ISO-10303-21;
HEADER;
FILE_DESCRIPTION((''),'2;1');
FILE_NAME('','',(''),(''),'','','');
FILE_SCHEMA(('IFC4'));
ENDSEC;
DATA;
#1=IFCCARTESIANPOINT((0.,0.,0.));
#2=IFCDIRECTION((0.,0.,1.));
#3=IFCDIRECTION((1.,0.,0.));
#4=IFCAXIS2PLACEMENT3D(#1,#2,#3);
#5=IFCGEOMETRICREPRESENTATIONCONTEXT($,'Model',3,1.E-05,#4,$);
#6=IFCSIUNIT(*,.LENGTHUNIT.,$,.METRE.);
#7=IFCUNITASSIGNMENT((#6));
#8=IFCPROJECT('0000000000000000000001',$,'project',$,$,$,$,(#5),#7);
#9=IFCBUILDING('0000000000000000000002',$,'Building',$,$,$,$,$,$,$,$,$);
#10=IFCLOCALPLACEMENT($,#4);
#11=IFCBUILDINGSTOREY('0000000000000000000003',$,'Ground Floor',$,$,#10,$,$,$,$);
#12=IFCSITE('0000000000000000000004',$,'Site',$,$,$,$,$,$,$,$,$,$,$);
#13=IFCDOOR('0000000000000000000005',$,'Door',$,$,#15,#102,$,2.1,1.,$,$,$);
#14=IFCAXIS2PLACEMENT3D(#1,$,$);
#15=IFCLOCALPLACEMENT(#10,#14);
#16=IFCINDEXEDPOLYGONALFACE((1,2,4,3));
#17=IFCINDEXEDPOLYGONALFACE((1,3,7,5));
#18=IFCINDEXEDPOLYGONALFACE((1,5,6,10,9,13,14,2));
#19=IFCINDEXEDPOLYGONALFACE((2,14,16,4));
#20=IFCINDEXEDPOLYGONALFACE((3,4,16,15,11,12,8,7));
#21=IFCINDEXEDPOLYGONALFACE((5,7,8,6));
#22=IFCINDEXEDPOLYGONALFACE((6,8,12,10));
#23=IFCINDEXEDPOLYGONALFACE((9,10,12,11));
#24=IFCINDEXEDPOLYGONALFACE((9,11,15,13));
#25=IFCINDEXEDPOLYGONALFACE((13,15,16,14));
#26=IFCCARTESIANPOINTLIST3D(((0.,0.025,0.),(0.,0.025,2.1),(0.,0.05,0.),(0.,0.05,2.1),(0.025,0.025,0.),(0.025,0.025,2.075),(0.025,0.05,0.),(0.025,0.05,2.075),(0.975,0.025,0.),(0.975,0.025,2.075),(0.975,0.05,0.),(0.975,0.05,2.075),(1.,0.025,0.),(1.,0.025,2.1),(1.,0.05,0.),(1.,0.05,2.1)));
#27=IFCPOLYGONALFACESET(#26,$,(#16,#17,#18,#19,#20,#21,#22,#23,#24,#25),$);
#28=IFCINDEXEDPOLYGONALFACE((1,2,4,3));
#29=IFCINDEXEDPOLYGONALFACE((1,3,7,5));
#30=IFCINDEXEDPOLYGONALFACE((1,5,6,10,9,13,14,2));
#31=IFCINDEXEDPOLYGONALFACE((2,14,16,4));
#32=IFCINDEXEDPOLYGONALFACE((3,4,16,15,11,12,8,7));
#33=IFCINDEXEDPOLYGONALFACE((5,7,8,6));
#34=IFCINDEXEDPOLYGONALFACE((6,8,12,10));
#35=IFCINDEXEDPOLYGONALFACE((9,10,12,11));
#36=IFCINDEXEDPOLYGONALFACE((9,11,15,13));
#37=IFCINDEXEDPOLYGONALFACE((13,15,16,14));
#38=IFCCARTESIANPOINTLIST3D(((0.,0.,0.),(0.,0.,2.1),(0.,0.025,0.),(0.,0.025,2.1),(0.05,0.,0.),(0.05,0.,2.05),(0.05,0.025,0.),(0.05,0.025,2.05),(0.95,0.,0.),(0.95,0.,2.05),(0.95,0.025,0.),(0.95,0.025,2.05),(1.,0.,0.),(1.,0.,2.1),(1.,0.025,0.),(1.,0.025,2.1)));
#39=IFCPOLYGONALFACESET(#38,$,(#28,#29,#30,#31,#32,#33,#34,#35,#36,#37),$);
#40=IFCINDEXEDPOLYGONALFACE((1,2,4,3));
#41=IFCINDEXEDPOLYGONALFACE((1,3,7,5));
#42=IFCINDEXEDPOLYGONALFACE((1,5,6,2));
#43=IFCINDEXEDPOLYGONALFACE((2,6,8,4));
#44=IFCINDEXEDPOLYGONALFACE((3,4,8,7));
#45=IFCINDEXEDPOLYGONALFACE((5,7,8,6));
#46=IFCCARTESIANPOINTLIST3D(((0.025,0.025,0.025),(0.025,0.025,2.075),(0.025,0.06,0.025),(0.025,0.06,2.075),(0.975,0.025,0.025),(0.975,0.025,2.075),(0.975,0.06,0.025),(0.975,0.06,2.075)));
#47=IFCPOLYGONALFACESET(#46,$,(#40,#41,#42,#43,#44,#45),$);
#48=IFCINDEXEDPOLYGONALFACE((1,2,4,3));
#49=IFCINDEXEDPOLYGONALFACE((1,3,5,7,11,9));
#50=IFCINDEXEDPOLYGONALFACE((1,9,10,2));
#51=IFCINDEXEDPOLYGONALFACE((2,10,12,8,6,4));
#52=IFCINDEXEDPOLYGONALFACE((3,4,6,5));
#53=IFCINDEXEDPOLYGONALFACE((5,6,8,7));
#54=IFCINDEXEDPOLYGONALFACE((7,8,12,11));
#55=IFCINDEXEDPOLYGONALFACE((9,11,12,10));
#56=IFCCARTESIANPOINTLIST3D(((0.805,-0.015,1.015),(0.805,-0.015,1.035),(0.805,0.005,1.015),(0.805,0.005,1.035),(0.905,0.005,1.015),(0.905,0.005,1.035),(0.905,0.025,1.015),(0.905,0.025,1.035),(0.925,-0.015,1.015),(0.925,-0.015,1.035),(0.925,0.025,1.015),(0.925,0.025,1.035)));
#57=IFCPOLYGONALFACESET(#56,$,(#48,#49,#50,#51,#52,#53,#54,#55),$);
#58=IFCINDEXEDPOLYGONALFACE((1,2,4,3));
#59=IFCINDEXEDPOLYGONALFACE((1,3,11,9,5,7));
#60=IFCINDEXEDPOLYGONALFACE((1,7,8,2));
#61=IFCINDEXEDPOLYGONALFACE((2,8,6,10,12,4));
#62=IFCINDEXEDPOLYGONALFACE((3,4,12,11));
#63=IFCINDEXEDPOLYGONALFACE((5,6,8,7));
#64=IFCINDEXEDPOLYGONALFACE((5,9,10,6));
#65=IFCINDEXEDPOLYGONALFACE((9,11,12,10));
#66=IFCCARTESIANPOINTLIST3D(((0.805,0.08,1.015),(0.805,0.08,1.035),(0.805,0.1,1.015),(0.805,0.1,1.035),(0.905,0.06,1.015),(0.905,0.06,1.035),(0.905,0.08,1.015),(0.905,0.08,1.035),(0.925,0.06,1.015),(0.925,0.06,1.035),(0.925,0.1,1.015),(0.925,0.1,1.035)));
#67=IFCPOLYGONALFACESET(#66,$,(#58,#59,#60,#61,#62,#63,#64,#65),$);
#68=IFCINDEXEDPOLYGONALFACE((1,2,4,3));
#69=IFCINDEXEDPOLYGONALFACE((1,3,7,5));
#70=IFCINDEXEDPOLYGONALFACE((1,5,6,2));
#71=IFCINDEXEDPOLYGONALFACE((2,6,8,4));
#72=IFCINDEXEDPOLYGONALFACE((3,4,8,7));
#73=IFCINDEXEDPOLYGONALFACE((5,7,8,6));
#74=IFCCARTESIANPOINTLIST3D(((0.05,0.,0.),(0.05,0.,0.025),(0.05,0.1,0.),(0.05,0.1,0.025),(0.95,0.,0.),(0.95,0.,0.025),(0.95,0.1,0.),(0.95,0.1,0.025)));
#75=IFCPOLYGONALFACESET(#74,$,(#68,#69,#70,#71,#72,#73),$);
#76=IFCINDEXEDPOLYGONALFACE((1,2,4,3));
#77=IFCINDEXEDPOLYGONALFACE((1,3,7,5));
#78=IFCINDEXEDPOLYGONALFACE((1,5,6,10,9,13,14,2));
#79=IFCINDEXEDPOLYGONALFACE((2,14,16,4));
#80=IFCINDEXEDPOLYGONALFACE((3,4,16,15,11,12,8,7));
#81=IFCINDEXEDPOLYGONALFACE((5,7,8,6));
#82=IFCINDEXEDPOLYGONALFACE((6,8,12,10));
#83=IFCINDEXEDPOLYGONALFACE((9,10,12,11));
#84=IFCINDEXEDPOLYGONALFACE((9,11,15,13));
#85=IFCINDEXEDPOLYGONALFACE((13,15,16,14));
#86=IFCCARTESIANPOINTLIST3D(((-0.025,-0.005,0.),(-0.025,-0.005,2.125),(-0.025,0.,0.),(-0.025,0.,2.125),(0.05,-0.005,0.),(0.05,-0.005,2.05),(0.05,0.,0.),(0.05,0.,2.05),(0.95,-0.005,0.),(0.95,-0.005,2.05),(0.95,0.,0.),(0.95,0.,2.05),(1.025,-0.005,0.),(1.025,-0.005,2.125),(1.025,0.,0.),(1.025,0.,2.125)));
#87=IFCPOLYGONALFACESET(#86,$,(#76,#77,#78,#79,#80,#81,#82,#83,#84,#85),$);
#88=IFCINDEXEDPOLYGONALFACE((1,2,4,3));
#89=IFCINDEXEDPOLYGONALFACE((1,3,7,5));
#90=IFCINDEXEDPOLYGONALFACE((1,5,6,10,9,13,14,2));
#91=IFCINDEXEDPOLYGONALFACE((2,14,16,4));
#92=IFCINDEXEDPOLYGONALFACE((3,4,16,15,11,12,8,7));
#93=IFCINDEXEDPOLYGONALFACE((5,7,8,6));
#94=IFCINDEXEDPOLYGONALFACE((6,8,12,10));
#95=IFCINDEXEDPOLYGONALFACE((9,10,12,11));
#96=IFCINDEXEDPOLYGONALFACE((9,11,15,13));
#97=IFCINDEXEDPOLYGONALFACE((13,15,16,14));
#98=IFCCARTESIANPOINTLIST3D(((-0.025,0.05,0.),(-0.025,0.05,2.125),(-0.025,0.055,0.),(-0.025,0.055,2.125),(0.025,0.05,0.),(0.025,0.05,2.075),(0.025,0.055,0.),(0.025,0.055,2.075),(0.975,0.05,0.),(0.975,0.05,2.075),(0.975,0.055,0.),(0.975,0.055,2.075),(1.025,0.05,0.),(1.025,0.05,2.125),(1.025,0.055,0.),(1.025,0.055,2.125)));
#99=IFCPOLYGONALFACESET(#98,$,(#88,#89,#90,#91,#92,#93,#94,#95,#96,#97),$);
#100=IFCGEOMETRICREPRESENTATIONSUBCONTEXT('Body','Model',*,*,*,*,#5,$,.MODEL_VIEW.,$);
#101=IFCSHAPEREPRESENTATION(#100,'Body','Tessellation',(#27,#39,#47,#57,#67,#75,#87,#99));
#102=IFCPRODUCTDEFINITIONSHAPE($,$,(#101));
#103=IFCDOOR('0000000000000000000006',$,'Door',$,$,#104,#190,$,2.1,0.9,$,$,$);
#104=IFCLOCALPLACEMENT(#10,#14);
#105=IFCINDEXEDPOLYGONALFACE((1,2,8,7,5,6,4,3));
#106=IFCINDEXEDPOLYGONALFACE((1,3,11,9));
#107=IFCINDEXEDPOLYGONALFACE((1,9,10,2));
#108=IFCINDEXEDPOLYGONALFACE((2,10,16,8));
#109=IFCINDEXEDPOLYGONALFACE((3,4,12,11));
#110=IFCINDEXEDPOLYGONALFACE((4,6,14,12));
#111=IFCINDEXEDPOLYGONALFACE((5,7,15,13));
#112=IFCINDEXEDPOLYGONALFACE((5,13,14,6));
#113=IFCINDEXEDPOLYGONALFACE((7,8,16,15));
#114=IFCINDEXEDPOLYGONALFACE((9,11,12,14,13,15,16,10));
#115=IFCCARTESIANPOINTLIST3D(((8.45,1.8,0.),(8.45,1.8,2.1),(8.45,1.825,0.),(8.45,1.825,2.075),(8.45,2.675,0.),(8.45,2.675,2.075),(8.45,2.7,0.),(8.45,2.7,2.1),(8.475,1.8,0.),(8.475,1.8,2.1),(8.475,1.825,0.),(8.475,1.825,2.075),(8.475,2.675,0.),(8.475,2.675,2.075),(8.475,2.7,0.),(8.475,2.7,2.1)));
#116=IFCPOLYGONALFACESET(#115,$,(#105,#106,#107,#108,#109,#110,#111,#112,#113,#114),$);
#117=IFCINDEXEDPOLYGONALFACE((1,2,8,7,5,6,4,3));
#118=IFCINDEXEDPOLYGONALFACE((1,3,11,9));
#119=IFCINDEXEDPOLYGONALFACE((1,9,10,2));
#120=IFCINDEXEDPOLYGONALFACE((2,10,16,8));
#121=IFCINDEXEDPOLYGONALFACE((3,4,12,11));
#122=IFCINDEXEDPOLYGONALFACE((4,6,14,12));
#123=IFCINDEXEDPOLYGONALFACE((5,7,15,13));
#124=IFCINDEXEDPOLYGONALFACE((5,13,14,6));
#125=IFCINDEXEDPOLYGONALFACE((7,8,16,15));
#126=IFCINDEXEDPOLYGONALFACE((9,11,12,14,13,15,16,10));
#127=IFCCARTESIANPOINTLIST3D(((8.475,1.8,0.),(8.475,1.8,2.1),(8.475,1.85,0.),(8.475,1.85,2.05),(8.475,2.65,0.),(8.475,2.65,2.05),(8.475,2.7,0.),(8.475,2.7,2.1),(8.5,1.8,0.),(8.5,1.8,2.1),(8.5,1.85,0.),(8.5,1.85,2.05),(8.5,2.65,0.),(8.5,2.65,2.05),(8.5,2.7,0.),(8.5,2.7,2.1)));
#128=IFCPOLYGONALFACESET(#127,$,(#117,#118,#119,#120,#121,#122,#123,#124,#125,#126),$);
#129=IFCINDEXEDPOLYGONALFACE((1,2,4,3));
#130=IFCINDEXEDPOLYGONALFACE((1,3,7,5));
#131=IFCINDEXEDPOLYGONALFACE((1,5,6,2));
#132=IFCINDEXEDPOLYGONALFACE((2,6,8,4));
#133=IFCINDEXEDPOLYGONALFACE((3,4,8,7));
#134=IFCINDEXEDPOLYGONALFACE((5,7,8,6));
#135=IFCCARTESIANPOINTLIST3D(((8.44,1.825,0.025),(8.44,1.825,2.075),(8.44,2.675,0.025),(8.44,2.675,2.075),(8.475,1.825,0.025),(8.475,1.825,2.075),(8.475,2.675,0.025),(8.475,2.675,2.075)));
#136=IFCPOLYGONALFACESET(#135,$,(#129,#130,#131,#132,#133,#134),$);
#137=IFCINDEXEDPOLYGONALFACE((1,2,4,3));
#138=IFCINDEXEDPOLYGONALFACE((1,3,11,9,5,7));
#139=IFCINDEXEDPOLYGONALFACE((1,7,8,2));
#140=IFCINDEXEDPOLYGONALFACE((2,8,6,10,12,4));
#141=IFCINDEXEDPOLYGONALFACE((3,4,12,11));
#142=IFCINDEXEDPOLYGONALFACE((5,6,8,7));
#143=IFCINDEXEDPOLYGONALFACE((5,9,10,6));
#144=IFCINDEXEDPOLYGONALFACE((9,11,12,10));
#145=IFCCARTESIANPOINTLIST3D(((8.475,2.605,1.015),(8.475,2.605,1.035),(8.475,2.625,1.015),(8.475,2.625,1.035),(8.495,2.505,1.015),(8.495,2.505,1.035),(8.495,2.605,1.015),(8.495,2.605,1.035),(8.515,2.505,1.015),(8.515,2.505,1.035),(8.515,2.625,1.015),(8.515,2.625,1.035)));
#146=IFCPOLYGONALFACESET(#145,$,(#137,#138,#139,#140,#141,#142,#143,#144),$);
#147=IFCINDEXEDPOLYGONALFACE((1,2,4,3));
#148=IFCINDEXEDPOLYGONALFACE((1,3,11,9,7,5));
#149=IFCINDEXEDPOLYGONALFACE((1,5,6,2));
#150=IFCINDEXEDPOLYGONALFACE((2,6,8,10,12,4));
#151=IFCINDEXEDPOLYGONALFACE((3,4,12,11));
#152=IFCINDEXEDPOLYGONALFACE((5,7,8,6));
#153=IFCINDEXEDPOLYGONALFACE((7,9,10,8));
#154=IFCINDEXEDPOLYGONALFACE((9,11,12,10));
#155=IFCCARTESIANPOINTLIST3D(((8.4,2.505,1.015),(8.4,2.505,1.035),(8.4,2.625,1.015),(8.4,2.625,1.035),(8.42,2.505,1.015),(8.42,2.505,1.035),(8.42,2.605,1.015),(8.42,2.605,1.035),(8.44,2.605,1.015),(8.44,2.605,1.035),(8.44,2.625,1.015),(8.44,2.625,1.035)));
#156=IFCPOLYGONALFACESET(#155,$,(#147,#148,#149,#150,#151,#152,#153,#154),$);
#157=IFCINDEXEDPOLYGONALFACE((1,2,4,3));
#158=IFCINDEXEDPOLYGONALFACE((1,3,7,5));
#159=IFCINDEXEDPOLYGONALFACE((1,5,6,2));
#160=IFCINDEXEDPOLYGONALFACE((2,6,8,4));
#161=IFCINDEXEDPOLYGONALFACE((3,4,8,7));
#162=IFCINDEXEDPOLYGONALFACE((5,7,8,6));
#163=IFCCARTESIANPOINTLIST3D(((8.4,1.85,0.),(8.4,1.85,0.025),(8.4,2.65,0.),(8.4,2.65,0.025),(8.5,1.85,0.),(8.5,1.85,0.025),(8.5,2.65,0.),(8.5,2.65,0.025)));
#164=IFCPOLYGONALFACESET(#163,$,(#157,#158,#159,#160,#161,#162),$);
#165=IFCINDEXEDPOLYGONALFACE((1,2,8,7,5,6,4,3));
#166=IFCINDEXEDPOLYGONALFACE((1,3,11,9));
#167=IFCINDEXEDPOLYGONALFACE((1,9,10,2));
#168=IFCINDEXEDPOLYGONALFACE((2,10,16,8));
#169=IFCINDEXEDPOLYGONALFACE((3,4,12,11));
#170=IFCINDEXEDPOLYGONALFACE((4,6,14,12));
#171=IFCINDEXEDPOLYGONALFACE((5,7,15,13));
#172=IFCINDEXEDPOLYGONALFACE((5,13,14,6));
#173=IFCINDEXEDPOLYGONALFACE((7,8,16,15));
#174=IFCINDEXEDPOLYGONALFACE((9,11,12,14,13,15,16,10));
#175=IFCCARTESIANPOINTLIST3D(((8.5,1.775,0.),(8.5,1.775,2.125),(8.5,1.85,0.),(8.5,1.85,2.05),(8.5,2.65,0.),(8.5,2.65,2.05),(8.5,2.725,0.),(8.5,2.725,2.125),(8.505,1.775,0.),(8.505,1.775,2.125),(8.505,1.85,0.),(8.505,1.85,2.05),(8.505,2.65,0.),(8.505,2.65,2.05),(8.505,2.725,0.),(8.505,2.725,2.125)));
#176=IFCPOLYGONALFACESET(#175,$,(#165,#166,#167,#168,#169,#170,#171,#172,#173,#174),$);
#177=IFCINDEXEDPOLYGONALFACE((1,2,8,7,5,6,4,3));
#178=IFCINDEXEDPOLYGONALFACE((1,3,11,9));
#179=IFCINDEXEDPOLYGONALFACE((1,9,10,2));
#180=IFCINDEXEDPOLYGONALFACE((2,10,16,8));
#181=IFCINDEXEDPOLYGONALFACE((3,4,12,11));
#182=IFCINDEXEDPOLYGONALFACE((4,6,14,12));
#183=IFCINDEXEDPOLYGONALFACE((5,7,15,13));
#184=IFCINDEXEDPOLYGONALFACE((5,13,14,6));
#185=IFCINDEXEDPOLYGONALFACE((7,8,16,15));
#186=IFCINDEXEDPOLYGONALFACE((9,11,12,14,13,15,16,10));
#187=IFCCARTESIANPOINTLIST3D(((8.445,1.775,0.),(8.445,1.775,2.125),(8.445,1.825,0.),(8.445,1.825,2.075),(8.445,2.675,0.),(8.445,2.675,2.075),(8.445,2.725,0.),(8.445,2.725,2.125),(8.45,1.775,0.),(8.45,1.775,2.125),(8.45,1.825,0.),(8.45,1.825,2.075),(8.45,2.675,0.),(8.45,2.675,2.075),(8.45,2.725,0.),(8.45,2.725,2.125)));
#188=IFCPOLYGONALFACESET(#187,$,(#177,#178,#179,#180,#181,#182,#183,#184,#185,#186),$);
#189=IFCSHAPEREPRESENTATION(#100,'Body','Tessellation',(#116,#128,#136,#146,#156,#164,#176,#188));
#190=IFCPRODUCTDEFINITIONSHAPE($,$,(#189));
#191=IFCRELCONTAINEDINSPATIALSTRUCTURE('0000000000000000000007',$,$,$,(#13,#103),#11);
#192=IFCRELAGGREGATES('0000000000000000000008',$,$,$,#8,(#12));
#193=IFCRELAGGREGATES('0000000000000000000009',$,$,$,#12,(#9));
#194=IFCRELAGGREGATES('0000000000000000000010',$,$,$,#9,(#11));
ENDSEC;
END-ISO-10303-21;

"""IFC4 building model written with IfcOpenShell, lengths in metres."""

from ifc_helpers import new_model, si_unit, frame, origin_with_axes, place, context, subcontext, project, spatial, line, indexed_curve, outline, extrude, element, save


model = new_model("IFC4")

# Units and contexts
model_context = context("Model", 3, precision=1e-05, world=origin_with_axes())
body_context = subcontext(model_context, "Body", "Model", "MODEL_VIEW")
ifc_project = project(units=[si_unit("LENGTHUNIT", "METRE")], contexts=[model_context])

# Site, building, storey
site = spatial("IfcSite", under=ifc_project, Name="Site")
building = spatial("IfcBuilding", under=site, Name="Building")
storey_placement = place(None, origin_with_axes())
storey = spatial("IfcBuildingStorey", under=building, at=storey_placement, Name="Ground Floor")

# Doors
door_1_placement = place(storey_placement, origin_with_axes())
element("IfcDoor", 1, at=door_1_placement, inside=storey, Name="Door", OverallHeight=2.1, OverallWidth=1.0, context=body_context, shape_type="SweptSolid", body=[
    extrude(outline(indexed_curve([(0.0, 0.0), (0.0, 2.1), (1.0, 2.1), (1.0, 0.0), (0.975, 0.0), (0.975, 2.075), (0.025, 2.075), (0.025, 0.0)], segments=[line(1, 2, 3, 4, 5, 6, 7, 8, 1)])), frame((0.0, 0.025, 0.0), z_axis=(0.0, -1.0, 0.0), x_axis=(1.0, 0.0, 0.0)), (0.0, 0.0, -1.0), 0.025),
    extrude(outline(indexed_curve([(0.0, 0.0), (0.0, 2.1), (1.0, 2.1), (1.0, 0.0), (0.95, 0.0), (0.95, 2.05), (0.05, 2.05), (0.05, 0.0)], segments=[line(1, 2, 3, 4, 5, 6, 7, 8, 1)])), frame((0.0, 0.0, 0.0), z_axis=(0.0, -1.0, 0.0), x_axis=(1.0, 0.0, 0.0)), (0.0, 0.0, -1.0), 0.025),
    extrude(outline(indexed_curve([(0.0, 0.0), (0.95, 0.0), (0.95, 0.035), (0.0, 0.035)], segments=[line(1, 2, 3, 4, 1)])), frame((0.025, 0.025, 0.025), z_axis=(0.0, 0.0, 1.0), x_axis=(1.0, 0.0, 0.0)), (0.0, 0.0, 1.0), 2.05),
    extrude(outline(indexed_curve([(0.0, 0.0), (0.0, -0.04), (-0.12, -0.04), (-0.12, -0.02), (-0.02, -0.02), (-0.02, 0.0)], segments=[line(1, 2, 3, 4, 5, 6, 1)])), frame((0.925, 0.025, 1.015), z_axis=(0.0, 0.0, 1.0), x_axis=(1.0, 0.0, 0.0)), (0.0, 0.0, 1.0), 0.02),
    extrude(outline(indexed_curve([(0.0, 0.0), (0.0, 0.04), (-0.12, 0.04), (-0.12, 0.02), (-0.02, 0.02), (-0.02, 0.0)], segments=[line(1, 2, 3, 4, 5, 6, 1)])), frame((0.925, 0.06, 1.015), z_axis=(0.0, 0.0, 1.0), x_axis=(1.0, 0.0, 0.0)), (0.0, 0.0, 1.0), 0.02),
    extrude(outline(indexed_curve([(0.0, 0.0), (0.9, 0.0), (0.9, 0.1), (0.0, 0.1)], segments=[line(1, 2, 3, 4, 1)])), frame((0.05, 0.0, 0.0), z_axis=(0.0, 0.0, 1.0), x_axis=(1.0, 0.0, 0.0)), (0.0, 0.0, 1.0), 0.025),
    extrude(outline(indexed_curve([(0.0, 0.0), (0.0, 2.125), (1.05, 2.125), (1.05, 0.0), (0.975, 0.0), (0.975, 2.05), (0.075, 2.05), (0.075, 0.0)], segments=[line(1, 2, 3, 4, 5, 6, 7, 8, 1)])), frame((-0.025, -0.005, 0.0), z_axis=(0.0, -1.0, 0.0), x_axis=(1.0, 0.0, 0.0)), (0.0, 0.0, -1.0), 0.005),
    extrude(outline(indexed_curve([(0.0, 0.0), (0.0, 2.125), (1.05, 2.125), (1.05, 0.0), (1.0, 0.0), (1.0, 2.075), (0.05, 2.075), (0.05, 0.0)], segments=[line(1, 2, 3, 4, 5, 6, 7, 8, 1)])), frame((-0.025, 0.05, 0.0), z_axis=(0.0, -1.0, 0.0), x_axis=(1.0, 0.0, 0.0)), (0.0, 0.0, -1.0), 0.005),
])
door_2_placement = place(storey_placement, frame((8.5, 1.8, 0.0), z_axis=(0.0, 0.0, 1.0), x_axis=(0.0, 1.0, 0.0)))
element("IfcDoor", 2, at=door_2_placement, inside=storey, Name="Door", OverallHeight=2.1, OverallWidth=0.9, context=body_context, shape_type="SweptSolid", body=[
    extrude(outline(indexed_curve([(0.0, 0.0), (0.0, 2.1), (0.9, 2.1), (0.9, 0.0), (0.875, 0.0), (0.875, 2.075), (0.025, 2.075), (0.025, 0.0)], segments=[line(1, 2, 3, 4, 5, 6, 7, 8, 1)])), frame((0.0, 0.025, 0.0), z_axis=(0.0, -1.0, 0.0), x_axis=(1.0, 0.0, 0.0)), (0.0, 0.0, -1.0), 0.025),
    extrude(outline(indexed_curve([(0.0, 0.0), (0.0, 2.1), (0.9, 2.1), (0.9, 0.0), (0.85, 0.0), (0.85, 2.05), (0.05, 2.05), (0.05, 0.0)], segments=[line(1, 2, 3, 4, 5, 6, 7, 8, 1)])), frame((0.0, 0.0, 0.0), z_axis=(0.0, -1.0, 0.0), x_axis=(1.0, 0.0, 0.0)), (0.0, 0.0, -1.0), 0.025),
    extrude(outline(indexed_curve([(0.0, 0.0), (0.85, 0.0), (0.85, 0.035), (0.0, 0.035)], segments=[line(1, 2, 3, 4, 1)])), frame((0.025, 0.025, 0.025), z_axis=(0.0, 0.0, 1.0), x_axis=(1.0, 0.0, 0.0)), (0.0, 0.0, 1.0), 2.05),
    extrude(outline(indexed_curve([(0.0, 0.0), (0.0, -0.04), (-0.12, -0.04), (-0.12, -0.02), (-0.02, -0.02), (-0.02, 0.0)], segments=[line(1, 2, 3, 4, 5, 6, 1)])), frame((0.825, 0.025, 1.015), z_axis=(0.0, 0.0, 1.0), x_axis=(1.0, 0.0, 0.0)), (0.0, 0.0, 1.0), 0.02),
    extrude(outline(indexed_curve([(0.0, 0.0), (0.0, 0.04), (-0.12, 0.04), (-0.12, 0.02), (-0.02, 0.02), (-0.02, 0.0)], segments=[line(1, 2, 3, 4, 5, 6, 1)])), frame((0.825, 0.06, 1.015), z_axis=(0.0, 0.0, 1.0), x_axis=(1.0, 0.0, 0.0)), (0.0, 0.0, 1.0), 0.02),
    extrude(outline(indexed_curve([(0.0, 0.0), (0.8, 0.0), (0.8, 0.1), (0.0, 0.1)], segments=[line(1, 2, 3, 4, 1)])), frame((0.05, 0.0, 0.0), z_axis=(0.0, 0.0, 1.0), x_axis=(1.0, 0.0, 0.0)), (0.0, 0.0, 1.0), 0.025),
    extrude(outline(indexed_curve([(0.0, 0.0), (0.0, 2.125), (0.95, 2.125), (0.95, 0.0), (0.875, 0.0), (0.875, 2.05), (0.075, 2.05), (0.075, 0.0)], segments=[line(1, 2, 3, 4, 5, 6, 7, 8, 1)])), frame((-0.025, -0.005, 0.0), z_axis=(0.0, -1.0, 0.0), x_axis=(1.0, 0.0, 0.0)), (0.0, 0.0, -1.0), 0.005),
    extrude(outline(indexed_curve([(0.0, 0.0), (0.0, 2.125), (0.95, 2.125), (0.95, 0.0), (0.9, 0.0), (0.9, 2.075), (0.05, 2.075), (0.05, 0.0)], segments=[line(1, 2, 3, 4, 5, 6, 7, 8, 1)])), frame((-0.025, 0.05, 0.0), z_axis=(0.0, -1.0, 0.0), x_axis=(1.0, 0.0, 0.0)), (0.0, 0.0, -1.0), 0.005),
])

save(model, "model.ifc")
